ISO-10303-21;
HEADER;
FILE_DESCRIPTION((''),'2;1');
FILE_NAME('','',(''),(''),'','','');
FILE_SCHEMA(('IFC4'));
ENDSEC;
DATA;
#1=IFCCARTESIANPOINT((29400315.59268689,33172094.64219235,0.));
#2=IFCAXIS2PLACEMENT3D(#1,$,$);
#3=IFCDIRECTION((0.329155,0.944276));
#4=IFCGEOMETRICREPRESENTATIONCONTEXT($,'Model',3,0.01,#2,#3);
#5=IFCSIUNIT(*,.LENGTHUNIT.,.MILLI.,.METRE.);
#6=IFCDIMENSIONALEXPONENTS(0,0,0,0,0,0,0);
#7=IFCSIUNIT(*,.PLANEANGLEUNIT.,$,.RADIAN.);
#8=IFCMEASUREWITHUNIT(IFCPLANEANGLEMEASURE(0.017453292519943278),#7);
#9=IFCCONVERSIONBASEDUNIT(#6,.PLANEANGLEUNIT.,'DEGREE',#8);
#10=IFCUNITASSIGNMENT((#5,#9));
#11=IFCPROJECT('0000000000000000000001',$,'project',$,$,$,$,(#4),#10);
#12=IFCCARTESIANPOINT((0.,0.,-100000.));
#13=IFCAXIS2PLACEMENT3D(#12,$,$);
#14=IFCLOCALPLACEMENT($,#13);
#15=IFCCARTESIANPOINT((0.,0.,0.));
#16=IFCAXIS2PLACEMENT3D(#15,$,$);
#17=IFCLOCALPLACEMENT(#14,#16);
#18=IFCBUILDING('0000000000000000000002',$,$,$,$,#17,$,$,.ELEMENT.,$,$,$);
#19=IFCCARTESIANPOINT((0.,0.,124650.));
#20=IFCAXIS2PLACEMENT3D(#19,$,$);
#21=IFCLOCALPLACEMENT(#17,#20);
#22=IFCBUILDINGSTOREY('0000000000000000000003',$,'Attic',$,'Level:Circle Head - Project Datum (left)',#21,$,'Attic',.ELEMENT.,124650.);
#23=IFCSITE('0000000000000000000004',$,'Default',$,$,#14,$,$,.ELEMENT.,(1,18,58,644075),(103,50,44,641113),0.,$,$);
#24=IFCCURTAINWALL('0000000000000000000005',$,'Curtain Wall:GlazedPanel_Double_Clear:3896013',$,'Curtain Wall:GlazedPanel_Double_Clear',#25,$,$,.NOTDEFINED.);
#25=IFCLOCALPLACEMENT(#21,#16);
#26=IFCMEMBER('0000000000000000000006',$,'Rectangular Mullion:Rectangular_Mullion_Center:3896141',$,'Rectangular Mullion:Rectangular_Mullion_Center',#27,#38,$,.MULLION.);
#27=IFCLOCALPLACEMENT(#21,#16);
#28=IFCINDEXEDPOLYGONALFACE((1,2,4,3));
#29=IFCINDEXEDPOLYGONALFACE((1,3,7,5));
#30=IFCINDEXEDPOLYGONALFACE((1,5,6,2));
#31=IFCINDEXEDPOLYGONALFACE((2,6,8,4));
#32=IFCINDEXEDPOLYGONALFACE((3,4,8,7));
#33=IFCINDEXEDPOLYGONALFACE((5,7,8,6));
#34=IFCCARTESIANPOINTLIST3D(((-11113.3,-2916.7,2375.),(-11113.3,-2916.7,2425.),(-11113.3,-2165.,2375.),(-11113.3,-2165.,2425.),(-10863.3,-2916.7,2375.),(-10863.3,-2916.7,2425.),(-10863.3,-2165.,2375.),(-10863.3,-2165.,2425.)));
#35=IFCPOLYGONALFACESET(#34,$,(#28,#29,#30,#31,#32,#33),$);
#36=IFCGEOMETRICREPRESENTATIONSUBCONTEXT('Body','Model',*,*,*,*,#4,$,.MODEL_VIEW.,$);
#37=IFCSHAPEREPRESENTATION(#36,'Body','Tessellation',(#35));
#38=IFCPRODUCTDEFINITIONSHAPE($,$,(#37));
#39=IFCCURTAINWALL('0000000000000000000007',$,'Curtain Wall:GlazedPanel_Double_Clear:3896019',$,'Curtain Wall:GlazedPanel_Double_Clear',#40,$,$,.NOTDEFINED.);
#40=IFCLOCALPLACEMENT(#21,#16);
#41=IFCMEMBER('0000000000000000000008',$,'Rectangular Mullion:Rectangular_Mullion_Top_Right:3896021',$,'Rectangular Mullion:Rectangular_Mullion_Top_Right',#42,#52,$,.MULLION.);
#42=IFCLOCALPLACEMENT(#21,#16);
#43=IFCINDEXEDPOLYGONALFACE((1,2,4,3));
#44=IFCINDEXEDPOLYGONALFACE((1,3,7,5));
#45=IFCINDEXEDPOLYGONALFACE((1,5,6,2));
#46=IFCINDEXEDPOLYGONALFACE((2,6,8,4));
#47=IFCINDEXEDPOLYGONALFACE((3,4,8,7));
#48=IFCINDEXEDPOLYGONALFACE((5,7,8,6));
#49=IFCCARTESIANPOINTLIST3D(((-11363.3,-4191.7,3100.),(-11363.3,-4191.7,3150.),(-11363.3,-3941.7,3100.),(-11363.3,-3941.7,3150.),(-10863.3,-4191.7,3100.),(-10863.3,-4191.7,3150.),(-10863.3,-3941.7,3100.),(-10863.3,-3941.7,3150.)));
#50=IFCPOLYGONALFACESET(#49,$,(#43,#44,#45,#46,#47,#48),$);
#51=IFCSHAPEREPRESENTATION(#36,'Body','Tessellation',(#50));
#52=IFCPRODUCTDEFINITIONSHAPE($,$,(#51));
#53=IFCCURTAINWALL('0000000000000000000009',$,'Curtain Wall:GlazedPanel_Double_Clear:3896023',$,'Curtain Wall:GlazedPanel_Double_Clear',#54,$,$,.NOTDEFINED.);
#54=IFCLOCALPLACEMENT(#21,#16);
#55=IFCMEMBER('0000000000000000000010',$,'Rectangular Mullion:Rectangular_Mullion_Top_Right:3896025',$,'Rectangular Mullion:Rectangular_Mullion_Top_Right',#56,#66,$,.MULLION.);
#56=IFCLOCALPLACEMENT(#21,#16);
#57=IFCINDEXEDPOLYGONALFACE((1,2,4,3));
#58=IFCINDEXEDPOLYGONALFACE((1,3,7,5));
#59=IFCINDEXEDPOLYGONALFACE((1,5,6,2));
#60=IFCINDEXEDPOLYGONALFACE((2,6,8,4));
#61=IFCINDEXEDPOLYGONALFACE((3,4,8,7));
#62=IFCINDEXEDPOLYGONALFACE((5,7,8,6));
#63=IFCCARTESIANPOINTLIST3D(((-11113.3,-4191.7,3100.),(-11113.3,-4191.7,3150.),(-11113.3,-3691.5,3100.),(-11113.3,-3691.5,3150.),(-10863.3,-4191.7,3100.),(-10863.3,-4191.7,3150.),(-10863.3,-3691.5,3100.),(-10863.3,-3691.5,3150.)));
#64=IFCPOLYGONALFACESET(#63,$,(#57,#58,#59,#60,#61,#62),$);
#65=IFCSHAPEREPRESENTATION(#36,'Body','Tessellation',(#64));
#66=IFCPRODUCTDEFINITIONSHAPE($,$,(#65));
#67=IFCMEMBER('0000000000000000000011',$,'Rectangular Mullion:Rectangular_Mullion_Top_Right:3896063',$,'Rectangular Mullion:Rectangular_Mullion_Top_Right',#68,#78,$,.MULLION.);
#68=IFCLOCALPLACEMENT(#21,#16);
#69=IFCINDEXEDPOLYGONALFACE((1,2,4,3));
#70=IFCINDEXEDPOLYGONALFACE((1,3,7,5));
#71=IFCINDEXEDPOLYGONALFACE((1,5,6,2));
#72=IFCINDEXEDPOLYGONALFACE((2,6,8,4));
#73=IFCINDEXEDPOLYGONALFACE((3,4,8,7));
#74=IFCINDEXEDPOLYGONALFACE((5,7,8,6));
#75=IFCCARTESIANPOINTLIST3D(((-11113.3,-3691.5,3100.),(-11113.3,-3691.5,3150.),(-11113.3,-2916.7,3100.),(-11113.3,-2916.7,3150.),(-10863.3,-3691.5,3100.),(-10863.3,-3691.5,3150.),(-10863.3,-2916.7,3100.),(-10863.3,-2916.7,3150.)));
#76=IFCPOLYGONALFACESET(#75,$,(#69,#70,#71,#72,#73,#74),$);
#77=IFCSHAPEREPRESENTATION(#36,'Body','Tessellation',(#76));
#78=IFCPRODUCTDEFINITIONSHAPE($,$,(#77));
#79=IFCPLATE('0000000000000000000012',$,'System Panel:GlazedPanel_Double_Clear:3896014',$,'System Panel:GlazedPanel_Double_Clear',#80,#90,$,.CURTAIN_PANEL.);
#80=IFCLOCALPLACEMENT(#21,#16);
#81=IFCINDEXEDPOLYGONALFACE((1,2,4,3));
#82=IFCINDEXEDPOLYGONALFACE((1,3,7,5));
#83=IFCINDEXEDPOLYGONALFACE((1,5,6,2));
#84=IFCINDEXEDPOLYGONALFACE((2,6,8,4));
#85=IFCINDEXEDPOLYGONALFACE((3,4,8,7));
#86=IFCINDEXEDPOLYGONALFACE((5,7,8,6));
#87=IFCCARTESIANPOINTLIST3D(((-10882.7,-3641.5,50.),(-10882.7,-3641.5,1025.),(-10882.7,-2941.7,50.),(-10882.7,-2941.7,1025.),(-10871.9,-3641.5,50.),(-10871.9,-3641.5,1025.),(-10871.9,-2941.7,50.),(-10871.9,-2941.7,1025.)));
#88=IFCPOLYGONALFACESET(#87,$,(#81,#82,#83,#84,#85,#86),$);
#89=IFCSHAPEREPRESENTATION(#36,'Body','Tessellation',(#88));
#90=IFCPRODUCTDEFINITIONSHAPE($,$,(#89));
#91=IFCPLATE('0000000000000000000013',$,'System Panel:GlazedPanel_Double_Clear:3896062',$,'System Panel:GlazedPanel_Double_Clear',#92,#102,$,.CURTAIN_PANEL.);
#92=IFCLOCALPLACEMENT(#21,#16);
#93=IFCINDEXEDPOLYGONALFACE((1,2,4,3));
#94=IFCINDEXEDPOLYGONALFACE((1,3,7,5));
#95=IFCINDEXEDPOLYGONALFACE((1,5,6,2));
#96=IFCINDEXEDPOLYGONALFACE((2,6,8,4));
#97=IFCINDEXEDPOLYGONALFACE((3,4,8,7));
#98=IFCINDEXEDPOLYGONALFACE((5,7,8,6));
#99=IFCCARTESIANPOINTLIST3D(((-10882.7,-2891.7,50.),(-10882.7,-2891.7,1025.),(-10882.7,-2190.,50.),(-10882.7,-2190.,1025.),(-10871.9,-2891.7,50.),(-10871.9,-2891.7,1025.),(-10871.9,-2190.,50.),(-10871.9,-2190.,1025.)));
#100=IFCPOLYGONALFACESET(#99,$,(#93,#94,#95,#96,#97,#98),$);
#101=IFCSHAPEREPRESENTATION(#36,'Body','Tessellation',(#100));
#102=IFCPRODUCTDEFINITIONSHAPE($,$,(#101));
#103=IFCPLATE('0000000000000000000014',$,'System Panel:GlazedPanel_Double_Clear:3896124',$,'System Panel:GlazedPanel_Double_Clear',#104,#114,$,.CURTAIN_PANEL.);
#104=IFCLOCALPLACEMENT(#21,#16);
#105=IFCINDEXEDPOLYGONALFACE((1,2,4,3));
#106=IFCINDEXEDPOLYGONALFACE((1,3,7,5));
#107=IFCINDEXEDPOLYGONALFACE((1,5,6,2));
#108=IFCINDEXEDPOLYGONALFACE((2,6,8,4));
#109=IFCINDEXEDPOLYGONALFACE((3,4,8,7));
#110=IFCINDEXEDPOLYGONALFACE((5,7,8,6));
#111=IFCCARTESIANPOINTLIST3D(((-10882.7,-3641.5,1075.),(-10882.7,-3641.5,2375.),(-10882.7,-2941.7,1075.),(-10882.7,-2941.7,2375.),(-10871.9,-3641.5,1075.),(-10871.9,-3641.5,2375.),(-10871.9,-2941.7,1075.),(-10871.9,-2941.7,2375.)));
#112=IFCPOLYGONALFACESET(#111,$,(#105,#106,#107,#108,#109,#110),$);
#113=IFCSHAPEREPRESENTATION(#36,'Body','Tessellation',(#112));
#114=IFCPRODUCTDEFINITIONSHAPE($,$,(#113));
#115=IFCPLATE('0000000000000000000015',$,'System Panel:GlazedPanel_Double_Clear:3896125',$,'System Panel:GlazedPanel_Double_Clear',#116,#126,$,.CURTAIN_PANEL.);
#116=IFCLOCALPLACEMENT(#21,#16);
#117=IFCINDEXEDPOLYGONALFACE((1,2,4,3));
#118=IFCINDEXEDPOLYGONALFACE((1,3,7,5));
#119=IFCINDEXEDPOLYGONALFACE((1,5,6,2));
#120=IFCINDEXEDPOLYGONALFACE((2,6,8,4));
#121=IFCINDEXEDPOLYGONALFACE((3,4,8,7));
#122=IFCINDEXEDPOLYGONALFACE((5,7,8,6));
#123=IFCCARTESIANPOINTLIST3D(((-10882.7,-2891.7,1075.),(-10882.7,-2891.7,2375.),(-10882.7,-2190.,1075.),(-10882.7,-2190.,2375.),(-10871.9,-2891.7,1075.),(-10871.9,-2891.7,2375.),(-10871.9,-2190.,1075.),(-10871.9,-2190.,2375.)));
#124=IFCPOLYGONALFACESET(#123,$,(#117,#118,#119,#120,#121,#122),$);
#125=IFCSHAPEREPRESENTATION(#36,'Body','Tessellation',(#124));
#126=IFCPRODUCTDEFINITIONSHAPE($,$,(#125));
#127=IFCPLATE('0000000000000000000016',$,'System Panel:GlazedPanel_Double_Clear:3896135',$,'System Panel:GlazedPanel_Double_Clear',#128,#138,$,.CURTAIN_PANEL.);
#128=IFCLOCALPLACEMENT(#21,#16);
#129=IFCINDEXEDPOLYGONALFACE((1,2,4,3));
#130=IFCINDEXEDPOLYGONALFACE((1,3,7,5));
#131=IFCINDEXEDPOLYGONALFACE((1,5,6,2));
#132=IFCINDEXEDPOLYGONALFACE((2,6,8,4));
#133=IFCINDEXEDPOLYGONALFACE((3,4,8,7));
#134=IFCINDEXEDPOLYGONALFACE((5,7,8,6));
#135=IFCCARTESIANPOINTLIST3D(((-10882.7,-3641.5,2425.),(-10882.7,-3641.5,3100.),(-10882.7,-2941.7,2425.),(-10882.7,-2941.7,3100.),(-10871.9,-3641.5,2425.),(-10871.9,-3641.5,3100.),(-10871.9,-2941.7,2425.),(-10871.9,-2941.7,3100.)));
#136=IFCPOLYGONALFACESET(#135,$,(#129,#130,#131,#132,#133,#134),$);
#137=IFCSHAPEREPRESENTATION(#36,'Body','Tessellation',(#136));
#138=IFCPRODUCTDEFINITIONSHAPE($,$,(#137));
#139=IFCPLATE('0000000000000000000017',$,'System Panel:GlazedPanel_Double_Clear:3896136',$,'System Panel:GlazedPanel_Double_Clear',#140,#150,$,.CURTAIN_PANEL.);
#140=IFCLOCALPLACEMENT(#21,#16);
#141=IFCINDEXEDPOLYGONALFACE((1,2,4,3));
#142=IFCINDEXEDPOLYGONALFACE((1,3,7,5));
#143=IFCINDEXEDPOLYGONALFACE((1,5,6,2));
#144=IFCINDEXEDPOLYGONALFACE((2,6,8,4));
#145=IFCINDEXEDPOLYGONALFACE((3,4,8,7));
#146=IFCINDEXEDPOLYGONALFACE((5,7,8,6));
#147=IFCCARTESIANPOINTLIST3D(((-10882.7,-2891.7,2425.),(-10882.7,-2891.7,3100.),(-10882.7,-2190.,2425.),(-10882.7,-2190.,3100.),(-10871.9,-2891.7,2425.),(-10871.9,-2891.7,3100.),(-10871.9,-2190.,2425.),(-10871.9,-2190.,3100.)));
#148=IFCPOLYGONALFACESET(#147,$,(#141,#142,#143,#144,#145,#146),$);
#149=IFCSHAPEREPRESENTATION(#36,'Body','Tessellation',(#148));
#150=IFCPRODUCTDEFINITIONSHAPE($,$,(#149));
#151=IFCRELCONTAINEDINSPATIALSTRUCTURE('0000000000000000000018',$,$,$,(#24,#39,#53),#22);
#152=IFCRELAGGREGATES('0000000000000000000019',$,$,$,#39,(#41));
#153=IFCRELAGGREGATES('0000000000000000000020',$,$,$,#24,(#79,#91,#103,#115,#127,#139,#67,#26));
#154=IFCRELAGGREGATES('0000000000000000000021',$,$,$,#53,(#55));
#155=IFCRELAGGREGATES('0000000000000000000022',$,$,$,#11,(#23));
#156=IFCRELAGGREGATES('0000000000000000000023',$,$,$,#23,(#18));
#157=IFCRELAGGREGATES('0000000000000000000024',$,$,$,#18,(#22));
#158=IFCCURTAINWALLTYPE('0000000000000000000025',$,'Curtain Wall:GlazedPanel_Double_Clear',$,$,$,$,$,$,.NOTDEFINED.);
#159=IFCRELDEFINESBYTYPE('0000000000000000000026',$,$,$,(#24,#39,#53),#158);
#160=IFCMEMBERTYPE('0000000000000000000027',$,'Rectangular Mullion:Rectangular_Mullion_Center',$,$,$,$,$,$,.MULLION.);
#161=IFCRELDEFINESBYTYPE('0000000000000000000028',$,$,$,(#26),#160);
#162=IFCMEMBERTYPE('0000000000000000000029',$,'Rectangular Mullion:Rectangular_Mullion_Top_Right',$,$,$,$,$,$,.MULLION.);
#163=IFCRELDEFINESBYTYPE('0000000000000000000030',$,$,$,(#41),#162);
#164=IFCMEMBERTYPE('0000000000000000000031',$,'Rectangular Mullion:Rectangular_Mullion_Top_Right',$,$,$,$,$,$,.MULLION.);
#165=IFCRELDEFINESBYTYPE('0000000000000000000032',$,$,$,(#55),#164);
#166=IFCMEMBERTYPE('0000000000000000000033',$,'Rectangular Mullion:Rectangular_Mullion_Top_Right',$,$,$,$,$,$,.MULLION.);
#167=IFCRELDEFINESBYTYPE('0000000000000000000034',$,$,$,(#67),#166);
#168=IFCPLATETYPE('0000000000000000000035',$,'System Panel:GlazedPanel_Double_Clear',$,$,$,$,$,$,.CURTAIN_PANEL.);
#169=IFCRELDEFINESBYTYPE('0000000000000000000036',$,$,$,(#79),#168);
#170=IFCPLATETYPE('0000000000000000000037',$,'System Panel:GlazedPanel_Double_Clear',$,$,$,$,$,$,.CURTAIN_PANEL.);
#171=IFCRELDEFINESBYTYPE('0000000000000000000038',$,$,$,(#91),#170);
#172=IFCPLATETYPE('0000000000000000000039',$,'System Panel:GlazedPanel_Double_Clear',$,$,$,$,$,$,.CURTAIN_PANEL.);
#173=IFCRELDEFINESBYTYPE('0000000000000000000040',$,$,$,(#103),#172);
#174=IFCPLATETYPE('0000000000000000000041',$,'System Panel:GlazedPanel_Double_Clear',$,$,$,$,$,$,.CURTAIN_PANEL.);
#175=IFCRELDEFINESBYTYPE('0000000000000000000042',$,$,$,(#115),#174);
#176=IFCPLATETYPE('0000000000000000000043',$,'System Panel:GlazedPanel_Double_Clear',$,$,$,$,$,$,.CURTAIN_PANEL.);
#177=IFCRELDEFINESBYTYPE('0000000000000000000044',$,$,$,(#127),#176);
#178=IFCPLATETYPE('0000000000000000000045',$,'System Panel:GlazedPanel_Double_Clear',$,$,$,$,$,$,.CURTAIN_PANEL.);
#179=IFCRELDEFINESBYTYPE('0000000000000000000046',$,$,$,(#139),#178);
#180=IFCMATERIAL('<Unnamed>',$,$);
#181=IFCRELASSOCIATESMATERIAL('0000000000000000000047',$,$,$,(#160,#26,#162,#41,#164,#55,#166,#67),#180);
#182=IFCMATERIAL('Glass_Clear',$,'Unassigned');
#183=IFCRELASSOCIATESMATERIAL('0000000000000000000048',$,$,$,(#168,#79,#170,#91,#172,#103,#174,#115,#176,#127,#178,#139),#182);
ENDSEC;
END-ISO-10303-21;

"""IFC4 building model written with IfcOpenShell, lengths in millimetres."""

from ifc_helpers import new_model, entity, si_unit, converted_unit, direction, frame, origin, place, context, subcontext, project, spatial, indexed_curve, outline, extrude, source, transform, mapped, material, type_object, type_shapes, element, aggregate, save


model = new_model("IFC4")

# Units and contexts
model_context = context("Model", 3, precision=0.01, world=frame((29400315.59268689, 33172094.64219235, 0.0)), true_north=direction((0.329155, 0.944276)))
body_context = subcontext(model_context, "Body", "Model", "MODEL_VIEW")
ifc_project = project(units=[si_unit("LENGTHUNIT", "METRE", prefix="MILLI"), converted_unit("PLANEANGLEUNIT", "DEGREE", entity("IfcPlaneAngleMeasure", 0.017453292519943278), si_unit("PLANEANGLEUNIT", "RADIAN"), dimensions=[0, 0, 0, 0, 0, 0, 0])], contexts=[model_context])

# Site, building, storey
site_placement = place(None, frame((0.0, 0.0, -100000.0)))
site = spatial("IfcSite", under=ifc_project, at=site_placement, Name="Default", CompositionType="ELEMENT", RefLatitude=(1, 18, 58, 644075), RefLongitude=(103, 50, 44, 641113), RefElevation=0.0)
building_placement = place(site_placement, origin())
building = spatial("IfcBuilding", under=site, at=building_placement, CompositionType="ELEMENT")
storey_placement = place(building_placement, frame((0.0, 0.0, 124650.0)))
storey = spatial("IfcBuildingStorey", under=building, at=storey_placement, Name="Attic", ObjectType="Level:Circle Head - Project Datum (left)", LongName="Attic", CompositionType="ELEMENT", Elevation=124650.0)

# Curtain wall, member
curtain_wall_type = type_object("IfcCurtainWallType", Name="Curtain Wall:GlazedPanel_Double_Clear", PredefinedType="NOTDEFINED")
curtain_wall_1_placement = place(storey_placement, frame((0.0, 0.0, -124650.0)))
curtain_wall_1 = element("IfcCurtainWall", 1, at=curtain_wall_1_placement, inside=storey, type_object=curtain_wall_type, Name="Curtain Wall:GlazedPanel_Double_Clear:3896013", ObjectType="Curtain Wall:GlazedPanel_Double_Clear", PredefinedType="NOTDEFINED")
ifc_material_1 = material(Name="<Unnamed>")
member_type_1 = type_object("IfcMemberType", Name="Rectangular Mullion:Rectangular_Mullion_Center", PredefinedType="MULLION", material=ifc_material_1)
shared_shape_1 = source(origin(), body_context, "Body", "SweptSolid", [
    extrude(outline(indexed_curve([(-25.0, -125.0), (25.0, -125.0), (25.0, 125.0), (-25.0, 125.0), (-25.0, -125.0)], self_intersect=False)), frame((0.0, 0.0, -751.7), z_axis=(0.0, 0.0, 1.0), x_axis=(-1.0, 0.0, 0.0)), (0.0, 0.0, 1.0), 751.7),
])
type_shapes(member_type_1, [shared_shape_1])
member_1_placement = place(curtain_wall_1_placement, frame((-10988.3, -2165.0, 127050.0), z_axis=(0.0, 1.0, 0.0), x_axis=(0.0, 0.0, 1.0)))
member_1 = element("IfcMember", 2, at=member_1_placement, type_object=member_type_1, material=ifc_material_1, Name="Rectangular Mullion:Rectangular_Mullion_Center:3896141", ObjectType="Rectangular Mullion:Rectangular_Mullion_Center", PredefinedType="MULLION", context=body_context, shape_type="MappedRepresentation", body=[
    mapped(shared_shape_1, transform((0.0, 0.0, 0.0), scale=1.0)),
])

# Curtain walls, members
curtain_wall_2_placement = place(storey_placement, frame((0.0, 0.0, -124650.0)))
curtain_wall_2 = element("IfcCurtainWall", 3, at=curtain_wall_2_placement, inside=storey, type_object=curtain_wall_type, Name="Curtain Wall:GlazedPanel_Double_Clear:3896019", ObjectType="Curtain Wall:GlazedPanel_Double_Clear", PredefinedType="NOTDEFINED")
member_type_2 = type_object("IfcMemberType", Name="Rectangular Mullion:Rectangular_Mullion_Top_Right", PredefinedType="MULLION", material=ifc_material_1)
shared_shape_2 = source(origin(), body_context, "Body", "SweptSolid", [
    extrude(outline(indexed_curve([(-25.0, -125.0), (25.0, -125.0), (25.0, 125.0), (-25.0, 125.0), (-25.0, -125.0)], self_intersect=False)), frame((-25.0, 0.0, -500.0), z_axis=(0.0, 0.0, 1.0), x_axis=(-1.0, 0.0, 0.0)), (0.0, 0.0, 1.0), 500.0),
])
type_shapes(member_type_2, [shared_shape_2])
member_2_placement = place(curtain_wall_2_placement, frame((-10863.3, -4066.7, 127800.0), z_axis=(1.0, 0.0, 0.0), x_axis=(0.0, 0.0, 1.0)))
member_2 = element("IfcMember", 4, at=member_2_placement, type_object=member_type_2, material=ifc_material_1, Name="Rectangular Mullion:Rectangular_Mullion_Top_Right:3896021", ObjectType="Rectangular Mullion:Rectangular_Mullion_Top_Right", PredefinedType="MULLION", context=body_context, shape_type="MappedRepresentation", body=[
    mapped(shared_shape_2, transform((0.0, 0.0, 0.0), scale=1.0)),
])
aggregate(curtain_wall_2, [member_2])
curtain_wall_3_placement = place(storey_placement, frame((0.0, 0.0, -124650.0)))
curtain_wall_3 = element("IfcCurtainWall", 5, at=curtain_wall_3_placement, inside=storey, type_object=curtain_wall_type, Name="Curtain Wall:GlazedPanel_Double_Clear:3896023", ObjectType="Curtain Wall:GlazedPanel_Double_Clear", PredefinedType="NOTDEFINED")
member_type_3 = type_object("IfcMemberType", Name="Rectangular Mullion:Rectangular_Mullion_Top_Right", PredefinedType="MULLION", material=ifc_material_1)
shared_shape_3 = source(origin(), body_context, "Body", "SweptSolid", [
    extrude(outline(indexed_curve([(-250.1, -125.0), (250.1, -125.0), (250.1, 125.0), (-250.1, 125.0), (-250.1, -125.0)], self_intersect=False)), frame((-50.0, 0.0, -250.1), z_axis=(1.0, 0.0, 0.0), x_axis=(0.0, 0.0, -1.0)), (0.0, 0.0, 1.0), 50.0),
])
type_shapes(member_type_3, [shared_shape_3])
member_3_placement = place(curtain_wall_3_placement, frame((-10988.3, -3691.5, 127800.0), z_axis=(0.0, 1.0, 0.0), x_axis=(0.0, 0.0, 1.0)))
member_3 = element("IfcMember", 6, at=member_3_placement, type_object=member_type_3, material=ifc_material_1, Name="Rectangular Mullion:Rectangular_Mullion_Top_Right:3896025", ObjectType="Rectangular Mullion:Rectangular_Mullion_Top_Right", PredefinedType="MULLION", context=body_context, shape_type="MappedRepresentation", body=[
    mapped(shared_shape_3, transform((0.0, 0.0, 0.0), scale=1.0)),
])

# Member
member_type_4 = type_object("IfcMemberType", Name="Rectangular Mullion:Rectangular_Mullion_Top_Right", PredefinedType="MULLION", material=ifc_material_1)
shared_shape_4 = source(origin(), body_context, "Body", "SweptSolid", [
    extrude(outline(indexed_curve([(-387.4, -125.0), (387.4, -125.0), (387.4, 125.0), (-387.4, 125.0), (-387.4, -125.0)], self_intersect=False)), frame((-50.0, 0.0, -387.4), z_axis=(1.0, 0.0, 0.0), x_axis=(0.0, 0.0, -1.0)), (0.0, 0.0, 1.0), 50.0),
])
type_shapes(member_type_4, [shared_shape_4])
member_4_placement = place(curtain_wall_1_placement, frame((-10988.3, -2916.7, 127800.0), z_axis=(0.0, 1.0, 0.0), x_axis=(0.0, 0.0, 1.0)))
member_4 = element("IfcMember", 7, at=member_4_placement, type_object=member_type_4, material=ifc_material_1, Name="Rectangular Mullion:Rectangular_Mullion_Top_Right:3896063", ObjectType="Rectangular Mullion:Rectangular_Mullion_Top_Right", PredefinedType="MULLION", context=body_context, shape_type="MappedRepresentation", body=[
    mapped(shared_shape_4, transform((0.0, 0.0, 0.0), scale=1.0)),
])

# Plates
ifc_material_2 = material(Name="Glass_Clear", Category="Unassigned")
plate_type_1 = type_object("IfcPlateType", Name="System Panel:GlazedPanel_Double_Clear", PredefinedType="CURTAIN_PANEL", material=ifc_material_2)
shared_shape_5 = source(origin(), body_context, "Body", "SweptSolid", [
    extrude(outline(indexed_curve([(-5.4, -349.9), (5.4, -349.9), (5.4, 349.9), (-5.4, 349.9), (-5.4, -349.9)], self_intersect=False)), frame((0.0, -111.0, 0.0), z_axis=(0.0, 0.0, 1.0), x_axis=(0.0, 1.0, 0.0)), (0.0, 0.0, 1.0), 975.0),
])
type_shapes(plate_type_1, [shared_shape_5])
plate_1_placement = place(curtain_wall_1_placement, frame((-10988.3, -3291.6, 124700.0), z_axis=(0.0, 0.0, 1.0), x_axis=(0.0, 1.0, 0.0)))
plate_1 = element("IfcPlate", 8, at=plate_1_placement, type_object=plate_type_1, material=ifc_material_2, Name="System Panel:GlazedPanel_Double_Clear:3896014", ObjectType="System Panel:GlazedPanel_Double_Clear", PredefinedType="CURTAIN_PANEL", context=body_context, shape_type="MappedRepresentation", body=[
    mapped(shared_shape_5, transform((0.0, 0.0, 0.0), scale=1.0)),
])
plate_type_2 = type_object("IfcPlateType", Name="System Panel:GlazedPanel_Double_Clear", PredefinedType="CURTAIN_PANEL", material=ifc_material_2)
shared_shape_6 = source(origin(), body_context, "Body", "SweptSolid", [
    extrude(outline(indexed_curve([(-5.4, -350.8), (5.4, -350.8), (5.4, 350.8), (-5.4, 350.8), (-5.4, -350.8)], self_intersect=False)), frame((0.0, -111.0, 0.0), z_axis=(0.0, 0.0, 1.0), x_axis=(0.0, 1.0, 0.0)), (0.0, 0.0, 1.0), 975.0),
])
type_shapes(plate_type_2, [shared_shape_6])
plate_2_placement = place(curtain_wall_1_placement, frame((-10988.3, -2540.9, 124700.0), z_axis=(0.0, 0.0, 1.0), x_axis=(0.0, 1.0, 0.0)))
plate_2 = element("IfcPlate", 9, at=plate_2_placement, type_object=plate_type_2, material=ifc_material_2, Name="System Panel:GlazedPanel_Double_Clear:3896062", ObjectType="System Panel:GlazedPanel_Double_Clear", PredefinedType="CURTAIN_PANEL", context=body_context, shape_type="MappedRepresentation", body=[
    mapped(shared_shape_6, transform((0.0, 0.0, 0.0), scale=1.0)),
])
plate_type_3 = type_object("IfcPlateType", Name="System Panel:GlazedPanel_Double_Clear", PredefinedType="CURTAIN_PANEL", material=ifc_material_2)
shared_shape_7 = source(origin(), body_context, "Body", "SweptSolid", [
    extrude(outline(indexed_curve([(-5.4, -349.9), (5.4, -349.9), (5.4, 349.9), (-5.4, 349.9), (-5.4, -349.9)], self_intersect=False)), frame((0.0, -111.0, 0.0), z_axis=(0.0, 0.0, 1.0), x_axis=(0.0, 1.0, 0.0)), (0.0, 0.0, 1.0), 1300.0),
])
type_shapes(plate_type_3, [shared_shape_7])
plate_3_placement = place(curtain_wall_1_placement, frame((-10988.3, -3291.6, 125725.0), z_axis=(0.0, 0.0, 1.0), x_axis=(0.0, 1.0, 0.0)))
plate_3 = element("IfcPlate", 10, at=plate_3_placement, type_object=plate_type_3, material=ifc_material_2, Name="System Panel:GlazedPanel_Double_Clear:3896124", ObjectType="System Panel:GlazedPanel_Double_Clear", PredefinedType="CURTAIN_PANEL", context=body_context, shape_type="MappedRepresentation", body=[
    mapped(shared_shape_7, transform((0.0, 0.0, 0.0), scale=1.0)),
])
plate_type_4 = type_object("IfcPlateType", Name="System Panel:GlazedPanel_Double_Clear", PredefinedType="CURTAIN_PANEL", material=ifc_material_2)
shared_shape_8 = source(origin(), body_context, "Body", "SweptSolid", [
    extrude(outline(indexed_curve([(-5.4, -350.8), (5.4, -350.8), (5.4, 350.8), (-5.4, 350.8), (-5.4, -350.8)], self_intersect=False)), frame((0.0, -111.0, 0.0), z_axis=(0.0, 0.0, 1.0), x_axis=(0.0, 1.0, 0.0)), (0.0, 0.0, 1.0), 1300.0),
])
type_shapes(plate_type_4, [shared_shape_8])
plate_4_placement = place(curtain_wall_1_placement, frame((-10988.3, -2540.9, 125725.0), z_axis=(0.0, 0.0, 1.0), x_axis=(0.0, 1.0, 0.0)))
plate_4 = element("IfcPlate", 11, at=plate_4_placement, type_object=plate_type_4, material=ifc_material_2, Name="System Panel:GlazedPanel_Double_Clear:3896125", ObjectType="System Panel:GlazedPanel_Double_Clear", PredefinedType="CURTAIN_PANEL", context=body_context, shape_type="MappedRepresentation", body=[
    mapped(shared_shape_8, transform((0.0, 0.0, 0.0), scale=1.0)),
])
plate_type_5 = type_object("IfcPlateType", Name="System Panel:GlazedPanel_Double_Clear", PredefinedType="CURTAIN_PANEL", material=ifc_material_2)
shared_shape_9 = source(origin(), body_context, "Body", "SweptSolid", [
    extrude(outline(indexed_curve([(-5.4, -349.9), (5.4, -349.9), (5.4, 349.9), (-5.4, 349.9), (-5.4, -349.9)], self_intersect=False)), frame((0.0, -111.0, 0.0), z_axis=(0.0, 0.0, 1.0), x_axis=(0.0, 1.0, 0.0)), (0.0, 0.0, 1.0), 675.0),
])
type_shapes(plate_type_5, [shared_shape_9])
plate_5_placement = place(curtain_wall_1_placement, frame((-10988.3, -3291.6, 127075.0), z_axis=(0.0, 0.0, 1.0), x_axis=(0.0, 1.0, 0.0)))
plate_5 = element("IfcPlate", 12, at=plate_5_placement, type_object=plate_type_5, material=ifc_material_2, Name="System Panel:GlazedPanel_Double_Clear:3896135", ObjectType="System Panel:GlazedPanel_Double_Clear", PredefinedType="CURTAIN_PANEL", context=body_context, shape_type="MappedRepresentation", body=[
    mapped(shared_shape_9, transform((0.0, 0.0, 0.0), scale=1.0)),
])
plate_type_6 = type_object("IfcPlateType", Name="System Panel:GlazedPanel_Double_Clear", PredefinedType="CURTAIN_PANEL", material=ifc_material_2)
shared_shape_10 = source(origin(), body_context, "Body", "SweptSolid", [
    extrude(outline(indexed_curve([(-5.4, -350.8), (5.4, -350.8), (5.4, 350.8), (-5.4, 350.8), (-5.4, -350.8)], self_intersect=False)), frame((0.0, -111.0, 0.0), z_axis=(0.0, 0.0, 1.0), x_axis=(0.0, 1.0, 0.0)), (0.0, 0.0, 1.0), 675.0),
])
type_shapes(plate_type_6, [shared_shape_10])
plate_6_placement = place(curtain_wall_1_placement, frame((-10988.3, -2540.9, 127075.0), z_axis=(0.0, 0.0, 1.0), x_axis=(0.0, 1.0, 0.0)))
plate_6 = element("IfcPlate", 13, at=plate_6_placement, type_object=plate_type_6, material=ifc_material_2, Name="System Panel:GlazedPanel_Double_Clear:3896136", ObjectType="System Panel:GlazedPanel_Double_Clear", PredefinedType="CURTAIN_PANEL", context=body_context, shape_type="MappedRepresentation", body=[
    mapped(shared_shape_10, transform((0.0, 0.0, 0.0), scale=1.0)),
])
aggregate(curtain_wall_1, [plate_1, plate_2, plate_3, plate_4, plate_5, plate_6, member_4, member_1])
aggregate(curtain_wall_3, [member_3])

save(model, "model.ifc")
